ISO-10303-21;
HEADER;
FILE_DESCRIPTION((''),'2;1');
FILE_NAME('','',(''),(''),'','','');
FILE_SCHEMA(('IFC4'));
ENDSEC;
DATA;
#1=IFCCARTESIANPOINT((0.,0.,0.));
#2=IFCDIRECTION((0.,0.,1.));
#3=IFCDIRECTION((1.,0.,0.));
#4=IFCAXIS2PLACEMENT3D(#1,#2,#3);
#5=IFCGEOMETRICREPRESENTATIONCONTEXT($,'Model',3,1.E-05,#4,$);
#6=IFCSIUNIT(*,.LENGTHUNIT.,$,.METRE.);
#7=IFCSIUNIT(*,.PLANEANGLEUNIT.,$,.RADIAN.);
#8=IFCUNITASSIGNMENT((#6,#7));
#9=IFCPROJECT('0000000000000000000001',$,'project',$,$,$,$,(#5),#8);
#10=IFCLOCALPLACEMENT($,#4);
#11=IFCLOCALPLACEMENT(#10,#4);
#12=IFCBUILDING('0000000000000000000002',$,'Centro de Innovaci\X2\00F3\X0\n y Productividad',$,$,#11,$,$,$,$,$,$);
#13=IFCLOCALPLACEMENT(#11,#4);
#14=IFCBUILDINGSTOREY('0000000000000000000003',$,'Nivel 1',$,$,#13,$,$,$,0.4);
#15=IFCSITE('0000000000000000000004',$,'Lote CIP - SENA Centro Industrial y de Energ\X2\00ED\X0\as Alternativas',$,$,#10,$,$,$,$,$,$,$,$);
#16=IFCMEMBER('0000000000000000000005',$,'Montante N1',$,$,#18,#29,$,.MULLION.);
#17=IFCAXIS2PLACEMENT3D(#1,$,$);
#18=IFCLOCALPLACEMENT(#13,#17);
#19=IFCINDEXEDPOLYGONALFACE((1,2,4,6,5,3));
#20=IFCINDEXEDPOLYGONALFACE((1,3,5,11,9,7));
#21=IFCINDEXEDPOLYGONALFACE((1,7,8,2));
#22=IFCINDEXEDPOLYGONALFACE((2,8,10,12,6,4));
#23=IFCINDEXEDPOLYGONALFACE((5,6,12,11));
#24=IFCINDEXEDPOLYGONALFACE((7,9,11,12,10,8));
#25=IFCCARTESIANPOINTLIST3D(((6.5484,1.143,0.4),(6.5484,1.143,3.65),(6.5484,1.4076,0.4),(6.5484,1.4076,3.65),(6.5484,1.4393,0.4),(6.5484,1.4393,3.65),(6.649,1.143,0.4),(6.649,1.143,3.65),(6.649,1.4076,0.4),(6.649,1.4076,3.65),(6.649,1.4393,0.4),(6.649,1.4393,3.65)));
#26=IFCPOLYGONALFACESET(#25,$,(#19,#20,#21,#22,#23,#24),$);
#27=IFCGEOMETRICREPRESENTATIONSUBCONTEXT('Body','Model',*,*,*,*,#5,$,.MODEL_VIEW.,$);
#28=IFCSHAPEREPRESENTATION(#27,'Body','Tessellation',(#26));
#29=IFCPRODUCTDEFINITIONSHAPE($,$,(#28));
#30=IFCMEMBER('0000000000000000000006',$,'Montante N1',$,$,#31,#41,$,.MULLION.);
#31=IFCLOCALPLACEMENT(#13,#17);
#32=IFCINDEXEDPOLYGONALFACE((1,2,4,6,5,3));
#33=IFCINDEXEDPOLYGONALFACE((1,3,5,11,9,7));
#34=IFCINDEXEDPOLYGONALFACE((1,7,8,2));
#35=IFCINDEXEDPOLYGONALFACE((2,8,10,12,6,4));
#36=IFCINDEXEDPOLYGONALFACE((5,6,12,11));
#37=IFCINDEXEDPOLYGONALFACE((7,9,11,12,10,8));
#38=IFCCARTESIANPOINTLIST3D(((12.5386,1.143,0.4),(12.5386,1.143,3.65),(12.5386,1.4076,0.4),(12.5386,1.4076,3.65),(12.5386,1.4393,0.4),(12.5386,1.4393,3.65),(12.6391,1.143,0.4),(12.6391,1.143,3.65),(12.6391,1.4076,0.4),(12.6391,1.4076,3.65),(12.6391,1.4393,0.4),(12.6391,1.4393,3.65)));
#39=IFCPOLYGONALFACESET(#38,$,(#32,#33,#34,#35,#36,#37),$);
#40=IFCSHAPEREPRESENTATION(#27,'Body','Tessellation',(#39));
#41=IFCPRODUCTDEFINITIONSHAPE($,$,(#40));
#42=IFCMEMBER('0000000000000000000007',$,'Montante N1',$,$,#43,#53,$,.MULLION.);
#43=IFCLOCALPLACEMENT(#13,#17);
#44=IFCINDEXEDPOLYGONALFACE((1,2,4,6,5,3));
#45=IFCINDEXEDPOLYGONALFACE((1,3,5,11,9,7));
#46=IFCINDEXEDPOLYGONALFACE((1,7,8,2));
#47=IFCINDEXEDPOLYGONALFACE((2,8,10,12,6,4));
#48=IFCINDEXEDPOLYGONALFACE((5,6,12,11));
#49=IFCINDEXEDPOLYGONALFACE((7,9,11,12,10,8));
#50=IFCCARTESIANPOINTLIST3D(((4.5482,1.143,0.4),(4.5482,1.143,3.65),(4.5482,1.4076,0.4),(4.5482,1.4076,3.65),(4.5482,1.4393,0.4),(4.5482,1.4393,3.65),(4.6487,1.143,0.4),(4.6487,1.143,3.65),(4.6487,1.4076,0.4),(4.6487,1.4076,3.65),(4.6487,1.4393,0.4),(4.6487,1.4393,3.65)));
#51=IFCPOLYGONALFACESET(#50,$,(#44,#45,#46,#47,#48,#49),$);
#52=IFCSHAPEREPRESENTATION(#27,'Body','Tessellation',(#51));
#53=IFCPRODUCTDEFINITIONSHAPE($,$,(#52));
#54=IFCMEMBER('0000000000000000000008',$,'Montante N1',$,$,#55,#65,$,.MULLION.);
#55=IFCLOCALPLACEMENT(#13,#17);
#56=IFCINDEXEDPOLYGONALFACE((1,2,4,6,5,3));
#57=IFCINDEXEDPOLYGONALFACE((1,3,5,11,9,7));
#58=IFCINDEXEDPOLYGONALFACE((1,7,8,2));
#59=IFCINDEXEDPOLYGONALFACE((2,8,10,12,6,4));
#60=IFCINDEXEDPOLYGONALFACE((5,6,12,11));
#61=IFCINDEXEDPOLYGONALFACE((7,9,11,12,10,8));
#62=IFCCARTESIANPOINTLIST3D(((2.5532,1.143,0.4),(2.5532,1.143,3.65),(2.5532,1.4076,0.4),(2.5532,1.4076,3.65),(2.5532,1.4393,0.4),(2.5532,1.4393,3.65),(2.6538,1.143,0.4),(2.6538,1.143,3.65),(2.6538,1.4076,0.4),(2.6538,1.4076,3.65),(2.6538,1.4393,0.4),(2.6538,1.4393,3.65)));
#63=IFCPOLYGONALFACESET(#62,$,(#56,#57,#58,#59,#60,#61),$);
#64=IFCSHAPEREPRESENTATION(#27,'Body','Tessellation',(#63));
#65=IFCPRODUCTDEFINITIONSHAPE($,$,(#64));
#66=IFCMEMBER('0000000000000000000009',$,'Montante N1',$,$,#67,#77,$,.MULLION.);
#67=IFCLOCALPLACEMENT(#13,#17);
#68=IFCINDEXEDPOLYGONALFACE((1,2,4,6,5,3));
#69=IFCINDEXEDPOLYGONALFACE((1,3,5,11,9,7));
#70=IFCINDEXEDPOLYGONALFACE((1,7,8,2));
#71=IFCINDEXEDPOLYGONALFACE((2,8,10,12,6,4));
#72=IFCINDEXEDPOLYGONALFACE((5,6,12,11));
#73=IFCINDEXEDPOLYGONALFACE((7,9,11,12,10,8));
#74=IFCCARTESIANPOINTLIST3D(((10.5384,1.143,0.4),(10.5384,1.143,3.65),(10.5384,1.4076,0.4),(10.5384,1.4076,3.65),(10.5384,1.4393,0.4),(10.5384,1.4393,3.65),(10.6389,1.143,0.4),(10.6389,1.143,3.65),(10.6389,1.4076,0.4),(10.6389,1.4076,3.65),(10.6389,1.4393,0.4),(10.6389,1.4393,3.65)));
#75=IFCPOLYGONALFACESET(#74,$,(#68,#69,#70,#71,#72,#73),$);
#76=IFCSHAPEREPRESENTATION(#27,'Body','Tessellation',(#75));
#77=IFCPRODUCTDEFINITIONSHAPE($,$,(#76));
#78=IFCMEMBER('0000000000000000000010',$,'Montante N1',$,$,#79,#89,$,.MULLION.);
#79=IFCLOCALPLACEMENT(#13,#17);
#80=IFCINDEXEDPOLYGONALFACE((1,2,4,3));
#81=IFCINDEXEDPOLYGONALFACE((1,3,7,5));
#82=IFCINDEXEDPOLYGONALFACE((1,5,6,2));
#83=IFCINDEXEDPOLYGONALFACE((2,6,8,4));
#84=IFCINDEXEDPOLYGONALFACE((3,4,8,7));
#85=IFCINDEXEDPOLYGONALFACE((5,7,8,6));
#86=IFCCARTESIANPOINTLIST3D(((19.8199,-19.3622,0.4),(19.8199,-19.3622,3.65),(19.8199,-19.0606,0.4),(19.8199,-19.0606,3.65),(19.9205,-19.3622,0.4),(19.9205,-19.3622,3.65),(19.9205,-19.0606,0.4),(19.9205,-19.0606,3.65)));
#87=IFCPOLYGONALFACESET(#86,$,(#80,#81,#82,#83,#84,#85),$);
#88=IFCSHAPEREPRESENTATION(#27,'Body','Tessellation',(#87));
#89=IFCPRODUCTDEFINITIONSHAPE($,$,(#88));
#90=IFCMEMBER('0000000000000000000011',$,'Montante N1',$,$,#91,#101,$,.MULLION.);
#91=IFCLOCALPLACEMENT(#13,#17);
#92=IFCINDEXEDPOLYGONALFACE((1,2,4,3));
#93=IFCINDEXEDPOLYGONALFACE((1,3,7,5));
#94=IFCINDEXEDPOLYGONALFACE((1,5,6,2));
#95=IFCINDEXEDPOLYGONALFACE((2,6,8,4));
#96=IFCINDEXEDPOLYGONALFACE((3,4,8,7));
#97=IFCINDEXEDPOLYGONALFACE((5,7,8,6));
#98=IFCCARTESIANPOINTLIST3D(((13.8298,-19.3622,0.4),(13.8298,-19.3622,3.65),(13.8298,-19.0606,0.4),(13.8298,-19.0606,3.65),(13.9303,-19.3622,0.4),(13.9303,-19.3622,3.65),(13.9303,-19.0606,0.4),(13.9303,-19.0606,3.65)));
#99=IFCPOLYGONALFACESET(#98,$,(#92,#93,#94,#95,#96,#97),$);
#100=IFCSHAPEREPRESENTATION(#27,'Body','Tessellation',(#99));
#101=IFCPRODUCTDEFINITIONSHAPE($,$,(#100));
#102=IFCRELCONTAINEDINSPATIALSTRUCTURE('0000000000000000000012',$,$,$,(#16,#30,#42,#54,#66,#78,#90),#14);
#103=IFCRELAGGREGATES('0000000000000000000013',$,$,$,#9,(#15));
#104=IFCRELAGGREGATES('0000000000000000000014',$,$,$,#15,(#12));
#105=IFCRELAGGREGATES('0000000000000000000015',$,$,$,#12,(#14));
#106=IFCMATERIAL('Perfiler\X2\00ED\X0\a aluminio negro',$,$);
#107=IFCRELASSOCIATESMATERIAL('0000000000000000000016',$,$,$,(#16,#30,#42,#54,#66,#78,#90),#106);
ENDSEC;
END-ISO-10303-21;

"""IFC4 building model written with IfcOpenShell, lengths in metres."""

from ifc_helpers import new_model, si_unit, frame, origin_with_axes, place, context, subcontext, project, spatial, polyline, outline, extrude, material, element, save


model = new_model("IFC4")

# Units and contexts
model_context = context("Model", 3, precision=1e-05, world=origin_with_axes())
body_context = subcontext(model_context, "Body", "Model", "MODEL_VIEW")
ifc_project = project(units=[si_unit("LENGTHUNIT", "METRE"), si_unit("PLANEANGLEUNIT", "RADIAN")], contexts=[model_context])

# Site, building, storey
site_placement = place(None, origin_with_axes())
site = spatial("IfcSite", under=ifc_project, at=site_placement, Name="Lote CIP - SENA Centro Industrial y de Energías Alternativas")
building_placement = place(site_placement, origin_with_axes())
building = spatial("IfcBuilding", under=site, at=building_placement, Name="Centro de Innovación y Productividad")
storey_placement = place(building_placement, origin_with_axes())
storey = spatial("IfcBuildingStorey", under=building, at=storey_placement, Name="Nivel 1", Elevation=0.4)

# Members
ifc_material = material(Name="Perfilería aluminio negro")
member_1_placement = place(storey_placement, origin_with_axes())
element("IfcMember", 1, at=member_1_placement, inside=storey, material=ifc_material, Name="Montante N1", PredefinedType="MULLION", context=body_context, shape_type="SweptSolid", body=[
    extrude(outline(polyline([(6.649, 1.4076), (6.649, 1.143), (6.5484, 1.143), (6.5484, 1.4076), (6.5484, 1.4393), (6.649, 1.4393), (6.649, 1.4076)])), frame((0.0, 0.0, 0.4)), (0.0, 0.0, 1.0), 3.25),
])
member_2_placement = place(storey_placement, origin_with_axes())
element("IfcMember", 2, at=member_2_placement, inside=storey, material=ifc_material, Name="Montante N1", PredefinedType="MULLION", context=body_context, shape_type="SweptSolid", body=[
    extrude(outline(polyline([(12.6391, 1.4076), (12.6391, 1.143), (12.5386, 1.143), (12.5386, 1.4076), (12.5386, 1.4393), (12.6391, 1.4393), (12.6391, 1.4076)])), frame((0.0, 0.0, 0.4)), (0.0, 0.0, 1.0), 3.25),
])
member_3_placement = place(storey_placement, origin_with_axes())
element("IfcMember", 3, at=member_3_placement, inside=storey, material=ifc_material, Name="Montante N1", PredefinedType="MULLION", context=body_context, shape_type="SweptSolid", body=[
    extrude(outline(polyline([(4.6487, 1.143), (4.5482, 1.143), (4.5482, 1.4076), (4.5482, 1.4393), (4.6487, 1.4393), (4.6487, 1.4076), (4.6487, 1.143)])), frame((0.0, 0.0, 0.4)), (0.0, 0.0, 1.0), 3.25),
])
member_4_placement = place(storey_placement, origin_with_axes())
element("IfcMember", 4, at=member_4_placement, inside=storey, material=ifc_material, Name="Montante N1", PredefinedType="MULLION", context=body_context, shape_type="SweptSolid", body=[
    extrude(outline(polyline([(2.6538, 1.4076), (2.6538, 1.143), (2.5532, 1.143), (2.5532, 1.4076), (2.5532, 1.4393), (2.6538, 1.4393), (2.6538, 1.4076)])), frame((0.0, 0.0, 0.4)), (0.0, 0.0, 1.0), 3.25),
])
member_5_placement = place(storey_placement, origin_with_axes())
element("IfcMember", 5, at=member_5_placement, inside=storey, material=ifc_material, Name="Montante N1", PredefinedType="MULLION", context=body_context, shape_type="SweptSolid", body=[
    extrude(outline(polyline([(10.5384, 1.143), (10.5384, 1.4076), (10.5384, 1.4393), (10.6389, 1.4393), (10.6389, 1.4076), (10.6389, 1.143), (10.5384, 1.143)])), frame((0.0, 0.0, 0.4)), (0.0, 0.0, 1.0), 3.25),
])
member_6_placement = place(storey_placement, origin_with_axes())
element("IfcMember", 6, at=member_6_placement, inside=storey, material=ifc_material, Name="Montante N1", PredefinedType="MULLION", context=body_context, shape_type="SweptSolid", body=[
    extrude(outline(polyline([(19.8199, -19.3622), (19.8199, -19.0606), (19.9205, -19.0606), (19.9205, -19.3622), (19.8199, -19.3622)])), frame((0.0, 0.0, 0.4)), (0.0, 0.0, 1.0), 3.25),
])
member_7_placement = place(storey_placement, origin_with_axes())
element("IfcMember", 7, at=member_7_placement, inside=storey, material=ifc_material, Name="Montante N1", PredefinedType="MULLION", context=body_context, shape_type="SweptSolid", body=[
    extrude(outline(polyline([(13.8298, -19.0606), (13.9303, -19.0606), (13.9303, -19.3622), (13.8298, -19.3622), (13.8298, -19.0606)])), frame((0.0, 0.0, 0.4)), (0.0, 0.0, 1.0), 3.25),
])

save(model, "model.ifc")
